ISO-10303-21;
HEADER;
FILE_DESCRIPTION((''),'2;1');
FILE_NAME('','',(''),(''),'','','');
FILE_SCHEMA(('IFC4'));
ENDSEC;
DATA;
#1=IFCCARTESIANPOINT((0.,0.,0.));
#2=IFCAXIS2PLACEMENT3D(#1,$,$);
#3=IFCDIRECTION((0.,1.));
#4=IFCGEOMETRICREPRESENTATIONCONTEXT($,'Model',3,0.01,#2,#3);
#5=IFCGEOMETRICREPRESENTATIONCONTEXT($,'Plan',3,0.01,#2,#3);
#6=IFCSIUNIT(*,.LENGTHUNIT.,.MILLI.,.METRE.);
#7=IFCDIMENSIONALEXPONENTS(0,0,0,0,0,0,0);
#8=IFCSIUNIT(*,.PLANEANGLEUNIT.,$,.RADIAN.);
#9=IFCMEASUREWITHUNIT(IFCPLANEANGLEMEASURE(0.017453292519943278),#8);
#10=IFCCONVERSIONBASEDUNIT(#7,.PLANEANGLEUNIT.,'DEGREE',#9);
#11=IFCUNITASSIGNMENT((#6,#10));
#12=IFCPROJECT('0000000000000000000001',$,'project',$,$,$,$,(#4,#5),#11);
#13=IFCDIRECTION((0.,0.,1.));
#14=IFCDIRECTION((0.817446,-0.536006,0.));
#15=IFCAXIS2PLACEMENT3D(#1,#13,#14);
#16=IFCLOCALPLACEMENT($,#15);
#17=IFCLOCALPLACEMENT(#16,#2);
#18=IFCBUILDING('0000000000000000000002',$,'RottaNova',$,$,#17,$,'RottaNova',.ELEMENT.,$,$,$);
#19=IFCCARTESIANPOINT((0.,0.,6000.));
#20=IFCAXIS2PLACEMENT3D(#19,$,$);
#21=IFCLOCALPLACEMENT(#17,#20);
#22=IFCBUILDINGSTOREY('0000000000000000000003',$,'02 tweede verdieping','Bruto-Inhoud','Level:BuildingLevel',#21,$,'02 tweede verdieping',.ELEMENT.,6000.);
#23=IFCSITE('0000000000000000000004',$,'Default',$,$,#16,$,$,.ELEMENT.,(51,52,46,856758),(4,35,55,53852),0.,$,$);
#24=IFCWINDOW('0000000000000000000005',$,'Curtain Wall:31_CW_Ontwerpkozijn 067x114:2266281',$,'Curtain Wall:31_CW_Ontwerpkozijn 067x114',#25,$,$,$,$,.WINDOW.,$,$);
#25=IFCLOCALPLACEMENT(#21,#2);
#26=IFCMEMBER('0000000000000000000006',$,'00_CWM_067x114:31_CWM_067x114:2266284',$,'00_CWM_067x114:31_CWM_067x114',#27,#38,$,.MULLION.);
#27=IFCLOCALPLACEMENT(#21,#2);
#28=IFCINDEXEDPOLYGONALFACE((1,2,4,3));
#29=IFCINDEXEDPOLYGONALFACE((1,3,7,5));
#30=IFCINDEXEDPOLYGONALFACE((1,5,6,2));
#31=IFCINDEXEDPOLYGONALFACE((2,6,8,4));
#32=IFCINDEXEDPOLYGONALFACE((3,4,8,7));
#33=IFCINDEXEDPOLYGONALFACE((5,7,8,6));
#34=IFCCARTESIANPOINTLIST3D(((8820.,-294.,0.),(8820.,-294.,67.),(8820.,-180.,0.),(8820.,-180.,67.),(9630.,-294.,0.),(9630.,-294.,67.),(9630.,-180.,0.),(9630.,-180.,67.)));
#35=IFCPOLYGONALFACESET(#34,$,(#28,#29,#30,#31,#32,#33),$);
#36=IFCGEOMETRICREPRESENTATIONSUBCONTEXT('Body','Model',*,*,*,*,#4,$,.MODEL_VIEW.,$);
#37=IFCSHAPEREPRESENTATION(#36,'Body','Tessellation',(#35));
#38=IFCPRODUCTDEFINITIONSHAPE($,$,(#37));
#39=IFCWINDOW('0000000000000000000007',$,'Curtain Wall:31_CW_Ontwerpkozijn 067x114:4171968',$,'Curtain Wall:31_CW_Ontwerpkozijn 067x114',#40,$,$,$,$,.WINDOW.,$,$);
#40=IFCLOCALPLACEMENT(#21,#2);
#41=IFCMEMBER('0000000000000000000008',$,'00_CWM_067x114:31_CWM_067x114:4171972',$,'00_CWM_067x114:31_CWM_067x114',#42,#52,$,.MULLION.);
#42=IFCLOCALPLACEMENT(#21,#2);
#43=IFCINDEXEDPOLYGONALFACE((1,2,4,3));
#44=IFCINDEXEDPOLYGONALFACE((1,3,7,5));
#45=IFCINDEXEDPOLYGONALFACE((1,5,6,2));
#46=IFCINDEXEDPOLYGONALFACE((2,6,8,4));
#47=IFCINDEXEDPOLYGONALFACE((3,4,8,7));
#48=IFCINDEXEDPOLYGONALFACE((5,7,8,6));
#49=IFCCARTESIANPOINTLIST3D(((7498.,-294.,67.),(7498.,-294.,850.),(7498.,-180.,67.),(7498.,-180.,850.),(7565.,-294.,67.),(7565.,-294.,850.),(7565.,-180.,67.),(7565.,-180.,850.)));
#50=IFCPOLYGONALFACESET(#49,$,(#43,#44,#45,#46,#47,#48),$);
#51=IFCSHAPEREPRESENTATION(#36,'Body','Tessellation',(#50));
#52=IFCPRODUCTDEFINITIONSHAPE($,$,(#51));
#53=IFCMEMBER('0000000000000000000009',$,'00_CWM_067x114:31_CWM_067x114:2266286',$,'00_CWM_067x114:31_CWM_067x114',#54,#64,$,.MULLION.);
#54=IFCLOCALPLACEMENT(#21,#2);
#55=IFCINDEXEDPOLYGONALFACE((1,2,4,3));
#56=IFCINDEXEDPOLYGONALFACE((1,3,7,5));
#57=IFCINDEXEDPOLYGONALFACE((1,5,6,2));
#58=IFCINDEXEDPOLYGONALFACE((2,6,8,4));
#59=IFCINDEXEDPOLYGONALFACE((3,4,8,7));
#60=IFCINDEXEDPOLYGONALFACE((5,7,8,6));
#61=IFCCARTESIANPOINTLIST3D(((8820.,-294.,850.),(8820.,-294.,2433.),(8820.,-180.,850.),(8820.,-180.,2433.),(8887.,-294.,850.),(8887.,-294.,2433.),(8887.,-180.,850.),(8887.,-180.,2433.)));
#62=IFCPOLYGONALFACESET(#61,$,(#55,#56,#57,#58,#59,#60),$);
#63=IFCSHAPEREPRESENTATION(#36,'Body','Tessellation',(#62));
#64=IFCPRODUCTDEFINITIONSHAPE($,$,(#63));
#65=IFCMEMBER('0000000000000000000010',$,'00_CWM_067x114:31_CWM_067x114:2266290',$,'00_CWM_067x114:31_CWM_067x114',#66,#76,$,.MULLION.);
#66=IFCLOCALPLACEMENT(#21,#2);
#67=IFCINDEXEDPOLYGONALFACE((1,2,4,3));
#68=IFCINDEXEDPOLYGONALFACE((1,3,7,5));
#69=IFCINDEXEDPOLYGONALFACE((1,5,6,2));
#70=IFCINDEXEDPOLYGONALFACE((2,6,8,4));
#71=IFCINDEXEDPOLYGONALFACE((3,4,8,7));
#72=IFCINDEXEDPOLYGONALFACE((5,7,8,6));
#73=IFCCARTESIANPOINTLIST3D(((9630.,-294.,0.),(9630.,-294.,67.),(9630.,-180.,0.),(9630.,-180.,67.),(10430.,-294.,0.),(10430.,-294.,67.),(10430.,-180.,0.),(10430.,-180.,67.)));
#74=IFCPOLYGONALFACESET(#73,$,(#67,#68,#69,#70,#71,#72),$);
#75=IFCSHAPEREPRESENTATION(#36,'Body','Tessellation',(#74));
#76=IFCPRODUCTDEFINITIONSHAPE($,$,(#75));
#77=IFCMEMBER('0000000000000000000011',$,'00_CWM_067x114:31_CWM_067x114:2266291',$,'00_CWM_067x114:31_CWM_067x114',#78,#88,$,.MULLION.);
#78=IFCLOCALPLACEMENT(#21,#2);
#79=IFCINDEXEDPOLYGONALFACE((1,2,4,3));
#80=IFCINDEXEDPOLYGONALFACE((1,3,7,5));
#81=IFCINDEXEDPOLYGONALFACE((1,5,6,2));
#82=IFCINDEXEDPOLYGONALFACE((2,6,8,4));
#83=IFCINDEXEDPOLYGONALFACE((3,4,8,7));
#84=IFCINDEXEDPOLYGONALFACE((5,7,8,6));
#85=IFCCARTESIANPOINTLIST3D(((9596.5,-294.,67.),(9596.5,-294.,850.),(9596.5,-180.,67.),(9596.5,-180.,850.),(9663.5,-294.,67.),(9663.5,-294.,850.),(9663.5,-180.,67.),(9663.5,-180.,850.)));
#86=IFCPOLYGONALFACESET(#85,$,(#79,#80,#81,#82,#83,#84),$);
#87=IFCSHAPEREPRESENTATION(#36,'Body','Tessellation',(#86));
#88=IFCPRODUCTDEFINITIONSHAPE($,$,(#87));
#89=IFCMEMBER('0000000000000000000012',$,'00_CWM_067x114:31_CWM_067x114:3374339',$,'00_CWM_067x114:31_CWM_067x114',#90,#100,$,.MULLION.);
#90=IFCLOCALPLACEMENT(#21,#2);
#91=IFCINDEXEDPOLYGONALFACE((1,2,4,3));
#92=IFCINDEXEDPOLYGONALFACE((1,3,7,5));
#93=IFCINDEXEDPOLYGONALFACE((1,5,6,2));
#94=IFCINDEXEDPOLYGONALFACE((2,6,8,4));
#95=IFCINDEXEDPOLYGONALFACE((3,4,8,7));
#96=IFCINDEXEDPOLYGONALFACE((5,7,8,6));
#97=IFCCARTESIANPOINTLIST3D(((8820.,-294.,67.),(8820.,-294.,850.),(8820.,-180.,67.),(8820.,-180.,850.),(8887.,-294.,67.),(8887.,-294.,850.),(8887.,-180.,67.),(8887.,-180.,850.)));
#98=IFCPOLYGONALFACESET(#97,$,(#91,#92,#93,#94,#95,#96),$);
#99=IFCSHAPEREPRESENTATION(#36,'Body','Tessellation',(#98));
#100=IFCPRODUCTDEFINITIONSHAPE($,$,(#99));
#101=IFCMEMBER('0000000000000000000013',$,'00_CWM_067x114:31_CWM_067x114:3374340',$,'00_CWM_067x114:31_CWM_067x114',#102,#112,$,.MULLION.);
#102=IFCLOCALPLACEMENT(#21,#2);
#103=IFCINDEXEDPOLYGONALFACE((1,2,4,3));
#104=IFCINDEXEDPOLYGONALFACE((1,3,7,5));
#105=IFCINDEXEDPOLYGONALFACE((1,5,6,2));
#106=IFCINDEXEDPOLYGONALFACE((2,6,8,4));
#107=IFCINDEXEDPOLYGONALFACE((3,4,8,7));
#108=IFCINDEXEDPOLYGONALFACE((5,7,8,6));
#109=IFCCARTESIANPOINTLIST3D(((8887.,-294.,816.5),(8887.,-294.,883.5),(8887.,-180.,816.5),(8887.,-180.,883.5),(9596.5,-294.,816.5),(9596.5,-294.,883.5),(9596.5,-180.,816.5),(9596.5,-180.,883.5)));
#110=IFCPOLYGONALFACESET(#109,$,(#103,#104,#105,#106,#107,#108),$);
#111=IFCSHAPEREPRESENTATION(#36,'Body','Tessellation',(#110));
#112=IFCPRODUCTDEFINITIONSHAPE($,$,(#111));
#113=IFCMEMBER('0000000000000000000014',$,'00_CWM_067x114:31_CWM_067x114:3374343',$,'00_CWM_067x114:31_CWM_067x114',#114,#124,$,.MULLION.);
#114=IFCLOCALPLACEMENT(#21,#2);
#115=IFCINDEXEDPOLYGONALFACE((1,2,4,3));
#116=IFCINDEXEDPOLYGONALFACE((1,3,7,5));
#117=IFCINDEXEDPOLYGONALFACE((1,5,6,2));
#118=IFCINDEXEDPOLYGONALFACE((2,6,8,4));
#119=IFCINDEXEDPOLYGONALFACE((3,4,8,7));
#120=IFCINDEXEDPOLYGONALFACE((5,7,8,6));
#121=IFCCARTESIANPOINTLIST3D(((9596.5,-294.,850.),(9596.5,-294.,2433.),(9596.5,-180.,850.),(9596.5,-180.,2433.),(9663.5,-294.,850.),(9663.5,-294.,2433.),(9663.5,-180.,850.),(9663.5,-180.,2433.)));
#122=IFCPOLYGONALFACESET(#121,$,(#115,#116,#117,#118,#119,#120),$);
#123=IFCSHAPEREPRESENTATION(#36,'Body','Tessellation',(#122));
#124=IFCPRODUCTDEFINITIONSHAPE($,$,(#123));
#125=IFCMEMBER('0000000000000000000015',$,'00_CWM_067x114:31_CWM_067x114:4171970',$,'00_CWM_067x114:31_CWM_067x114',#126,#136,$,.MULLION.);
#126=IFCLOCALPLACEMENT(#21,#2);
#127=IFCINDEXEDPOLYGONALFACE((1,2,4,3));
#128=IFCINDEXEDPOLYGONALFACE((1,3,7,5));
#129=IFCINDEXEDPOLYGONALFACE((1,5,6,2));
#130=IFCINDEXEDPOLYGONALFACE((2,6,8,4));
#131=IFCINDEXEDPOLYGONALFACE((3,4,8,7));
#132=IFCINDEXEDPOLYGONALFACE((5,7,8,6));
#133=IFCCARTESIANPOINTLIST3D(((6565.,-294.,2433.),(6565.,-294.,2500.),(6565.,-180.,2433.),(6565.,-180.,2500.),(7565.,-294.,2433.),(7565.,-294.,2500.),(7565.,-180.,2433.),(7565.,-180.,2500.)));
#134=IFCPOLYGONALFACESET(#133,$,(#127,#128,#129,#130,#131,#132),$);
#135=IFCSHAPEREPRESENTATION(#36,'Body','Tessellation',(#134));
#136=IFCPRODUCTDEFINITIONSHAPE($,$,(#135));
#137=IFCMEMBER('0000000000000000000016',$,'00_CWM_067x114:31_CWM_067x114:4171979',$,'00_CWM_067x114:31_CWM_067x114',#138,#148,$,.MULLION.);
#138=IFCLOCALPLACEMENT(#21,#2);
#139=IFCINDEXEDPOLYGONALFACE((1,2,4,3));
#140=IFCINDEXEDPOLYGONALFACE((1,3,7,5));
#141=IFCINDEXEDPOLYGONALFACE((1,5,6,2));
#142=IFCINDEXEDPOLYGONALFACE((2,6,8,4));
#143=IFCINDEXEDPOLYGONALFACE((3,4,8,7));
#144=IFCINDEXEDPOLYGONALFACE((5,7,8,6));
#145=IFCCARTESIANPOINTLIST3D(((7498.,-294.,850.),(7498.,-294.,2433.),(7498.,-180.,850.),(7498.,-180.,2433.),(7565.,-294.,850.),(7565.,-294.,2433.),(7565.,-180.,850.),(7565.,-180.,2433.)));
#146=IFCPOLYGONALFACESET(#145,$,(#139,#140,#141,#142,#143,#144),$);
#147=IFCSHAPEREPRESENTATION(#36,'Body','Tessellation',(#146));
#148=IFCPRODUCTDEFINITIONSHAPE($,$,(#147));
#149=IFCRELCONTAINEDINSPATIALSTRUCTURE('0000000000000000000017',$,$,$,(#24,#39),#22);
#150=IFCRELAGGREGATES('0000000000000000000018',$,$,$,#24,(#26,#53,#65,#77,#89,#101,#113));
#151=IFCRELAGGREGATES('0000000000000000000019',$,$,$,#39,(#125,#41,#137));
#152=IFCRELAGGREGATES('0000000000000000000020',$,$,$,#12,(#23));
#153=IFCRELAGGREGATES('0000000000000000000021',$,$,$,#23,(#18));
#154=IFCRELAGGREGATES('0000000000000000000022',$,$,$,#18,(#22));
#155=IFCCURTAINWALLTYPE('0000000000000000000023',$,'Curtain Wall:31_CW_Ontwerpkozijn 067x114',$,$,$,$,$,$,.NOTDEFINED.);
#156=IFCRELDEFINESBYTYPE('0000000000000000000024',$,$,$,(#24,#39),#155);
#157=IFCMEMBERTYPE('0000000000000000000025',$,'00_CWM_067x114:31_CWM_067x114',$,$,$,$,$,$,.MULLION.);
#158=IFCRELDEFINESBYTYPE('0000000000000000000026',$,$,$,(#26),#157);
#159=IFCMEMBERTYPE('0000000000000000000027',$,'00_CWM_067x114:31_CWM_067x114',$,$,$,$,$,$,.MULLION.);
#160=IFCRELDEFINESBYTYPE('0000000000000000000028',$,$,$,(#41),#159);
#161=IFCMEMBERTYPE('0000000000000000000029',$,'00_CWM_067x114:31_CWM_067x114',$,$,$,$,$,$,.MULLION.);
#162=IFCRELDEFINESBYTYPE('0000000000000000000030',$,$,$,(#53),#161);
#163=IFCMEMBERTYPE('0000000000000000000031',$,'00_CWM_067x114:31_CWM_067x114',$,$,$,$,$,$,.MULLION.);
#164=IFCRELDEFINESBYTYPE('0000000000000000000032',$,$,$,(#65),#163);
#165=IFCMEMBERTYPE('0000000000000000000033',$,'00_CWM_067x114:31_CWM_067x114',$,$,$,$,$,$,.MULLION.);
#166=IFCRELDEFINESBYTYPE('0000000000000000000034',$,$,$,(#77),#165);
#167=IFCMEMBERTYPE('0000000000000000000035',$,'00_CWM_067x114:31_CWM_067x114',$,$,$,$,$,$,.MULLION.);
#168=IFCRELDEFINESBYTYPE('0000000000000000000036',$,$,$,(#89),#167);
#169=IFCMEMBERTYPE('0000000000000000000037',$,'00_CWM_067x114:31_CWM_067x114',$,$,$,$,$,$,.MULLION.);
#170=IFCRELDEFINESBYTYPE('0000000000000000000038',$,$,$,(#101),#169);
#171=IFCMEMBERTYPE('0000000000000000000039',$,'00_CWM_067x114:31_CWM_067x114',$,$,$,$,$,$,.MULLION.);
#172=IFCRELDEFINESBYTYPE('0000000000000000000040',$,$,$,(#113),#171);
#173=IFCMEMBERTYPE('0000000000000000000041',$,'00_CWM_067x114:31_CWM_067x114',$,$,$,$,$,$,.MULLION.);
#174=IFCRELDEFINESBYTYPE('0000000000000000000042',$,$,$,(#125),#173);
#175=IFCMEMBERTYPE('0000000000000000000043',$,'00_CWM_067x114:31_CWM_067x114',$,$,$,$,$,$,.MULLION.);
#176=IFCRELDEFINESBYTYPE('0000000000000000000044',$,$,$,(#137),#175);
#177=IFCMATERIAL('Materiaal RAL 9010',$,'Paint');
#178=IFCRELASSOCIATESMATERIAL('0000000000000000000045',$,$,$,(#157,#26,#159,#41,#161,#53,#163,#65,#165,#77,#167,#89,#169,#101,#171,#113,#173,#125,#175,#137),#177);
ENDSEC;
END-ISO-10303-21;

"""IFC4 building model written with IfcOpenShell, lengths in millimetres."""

from ifc_helpers import new_model, entity, si_unit, converted_unit, direction, frame, origin, place, context, subcontext, project, spatial, indexed_curve, outline, extrude, source, transform, mapped, material, type_object, type_shapes, element, aggregate, save


model = new_model("IFC4")

# Units and contexts
model_context = context("Model", 3, precision=0.01, world=origin(), true_north=direction((0.0, 1.0)))
plan_context = context("Plan", 3, precision=0.01, world=origin(), true_north=direction((0.0, 1.0)))
body_context = subcontext(model_context, "Body", "Model", "MODEL_VIEW")
ifc_project = project(units=[si_unit("LENGTHUNIT", "METRE", prefix="MILLI"), converted_unit("PLANEANGLEUNIT", "DEGREE", entity("IfcPlaneAngleMeasure", 0.017453292519943278), si_unit("PLANEANGLEUNIT", "RADIAN"), dimensions=[0, 0, 0, 0, 0, 0, 0])], contexts=[model_context, plan_context])

# Site, building, storey
site_placement = place(None, frame((0.0, 0.0, 0.0), z_axis=(0.0, 0.0, 1.0), x_axis=(0.817446, -0.536006, 0.0)))
site = spatial("IfcSite", under=ifc_project, at=site_placement, Name="Default", CompositionType="ELEMENT", RefLatitude=(51, 52, 46, 856758), RefLongitude=(4, 35, 55, 53852), RefElevation=0.0)
building_placement = place(site_placement, origin())
building = spatial("IfcBuilding", under=site, at=building_placement, Name="RottaNova", LongName="RottaNova", CompositionType="ELEMENT")
storey_placement = place(building_placement, frame((0.0, 0.0, 6000.0)))
storey = spatial("IfcBuildingStorey", under=building, at=storey_placement, Name="02 tweede verdieping", Description="Bruto-Inhoud", ObjectType="Level:BuildingLevel", LongName="02 tweede verdieping", CompositionType="ELEMENT", Elevation=6000.0)

# Windows, members
curtain_wall_type = type_object("IfcCurtainWallType", Name="Curtain Wall:31_CW_Ontwerpkozijn 067x114", PredefinedType="NOTDEFINED")
window_1_placement = place(storey_placement, frame((0.0, 0.0, -6000.0)))
window_1 = element("IfcWindow", 1, at=window_1_placement, inside=storey, type_object=curtain_wall_type, Name="Curtain Wall:31_CW_Ontwerpkozijn 067x114:2266281", ObjectType="Curtain Wall:31_CW_Ontwerpkozijn 067x114", PredefinedType="WINDOW")
ifc_material_1 = material(Name="Materiaal RAL 9010", Category="Paint")
member_type_1 = type_object("IfcMemberType", Name="00_CWM_067x114:31_CWM_067x114", PredefinedType="MULLION", material=ifc_material_1)
shared_shape_1 = source(origin(), body_context, "Body", "SweptSolid", [
    extrude(outline(indexed_curve([(-33.5, -57.0), (33.5, -57.0), (33.5, 57.0), (-33.5, 57.0), (-33.5, -57.0)], self_intersect=False)), frame((-33.5, 57.0, -810.0), z_axis=(0.0, 0.0, 1.0), x_axis=(-1.0, 0.0, 0.0)), (0.0, 0.0, 1.0), 810.0),
])
type_shapes(member_type_1, [shared_shape_1])
member_1_placement = place(window_1_placement, frame((8820.0, -180.0, 6000.0), z_axis=(-1.0, 0.0, 0.0), x_axis=(0.0, 0.0, -1.0)))
member_1 = element("IfcMember", 2, at=member_1_placement, type_object=member_type_1, material=ifc_material_1, Name="00_CWM_067x114:31_CWM_067x114:2266284", ObjectType="00_CWM_067x114:31_CWM_067x114", PredefinedType="MULLION", context=body_context, shape_type="MappedRepresentation", body=[
    mapped(shared_shape_1, transform((0.0, 0.0, 0.0), scale=1.0)),
])
window_2_placement = place(storey_placement, frame((0.0, 0.0, -6000.0)))
window_2 = element("IfcWindow", 3, at=window_2_placement, inside=storey, type_object=curtain_wall_type, Name="Curtain Wall:31_CW_Ontwerpkozijn 067x114:4171968", ObjectType="Curtain Wall:31_CW_Ontwerpkozijn 067x114", PredefinedType="WINDOW")
member_type_2 = type_object("IfcMemberType", Name="00_CWM_067x114:31_CWM_067x114", PredefinedType="MULLION", material=ifc_material_1)
shared_shape_2 = source(origin(), body_context, "Body", "SweptSolid", [
    extrude(outline(indexed_curve([(-33.5, -57.0), (33.5, -57.0), (33.5, 57.0), (-33.5, 57.0), (-33.5, -57.0)], self_intersect=False)), frame((-33.5, 57.0, -783.0), z_axis=(0.0, 0.0, 1.0), x_axis=(-1.0, 0.0, 0.0)), (0.0, 0.0, 1.0), 783.0),
])
type_shapes(member_type_2, [shared_shape_2])
member_2_placement = place(window_2_placement, frame((7565.0, -180.0, 6067.0), z_axis=(0.0, 0.0, -1.0), x_axis=(1.0, 0.0, 0.0)))
member_2 = element("IfcMember", 4, at=member_2_placement, type_object=member_type_2, material=ifc_material_1, Name="00_CWM_067x114:31_CWM_067x114:4171972", ObjectType="00_CWM_067x114:31_CWM_067x114", PredefinedType="MULLION", context=body_context, shape_type="MappedRepresentation", body=[
    mapped(shared_shape_2, transform((0.0, 0.0, 0.0), scale=1.0)),
])

# Members
member_type_3 = type_object("IfcMemberType", Name="00_CWM_067x114:31_CWM_067x114", PredefinedType="MULLION", material=ifc_material_1)
shared_shape_3 = source(origin(), body_context, "Body", "SweptSolid", [
    extrude(outline(indexed_curve([(-33.5, -57.0), (33.5, -57.0), (33.5, 57.0), (-33.5, 57.0), (-33.5, -57.0)], self_intersect=False)), frame((-33.5, 57.0, -1583.0), z_axis=(0.0, 0.0, 1.0), x_axis=(-1.0, 0.0, 0.0)), (0.0, 0.0, 1.0), 1583.0),
])
type_shapes(member_type_3, [shared_shape_3])
member_3_placement = place(window_1_placement, frame((8820.0, -180.0, 8433.0), z_axis=(0.0, 0.0, 1.0), x_axis=(-1.0, 0.0, 0.0)))
member_3 = element("IfcMember", 5, at=member_3_placement, type_object=member_type_3, material=ifc_material_1, Name="00_CWM_067x114:31_CWM_067x114:2266286", ObjectType="00_CWM_067x114:31_CWM_067x114", PredefinedType="MULLION", context=body_context, shape_type="MappedRepresentation", body=[
    mapped(shared_shape_3, transform((0.0, 0.0, 0.0), scale=1.0)),
])
member_type_4 = type_object("IfcMemberType", Name="00_CWM_067x114:31_CWM_067x114", PredefinedType="MULLION", material=ifc_material_1)
shared_shape_4 = source(origin(), body_context, "Body", "SweptSolid", [
    extrude(outline(indexed_curve([(-33.5, -57.0), (33.5, -57.0), (33.5, 57.0), (-33.5, 57.0), (-33.5, -57.0)], self_intersect=False)), frame((-33.5, 57.0, -800.0), z_axis=(0.0, 0.0, 1.0), x_axis=(-1.0, 0.0, 0.0)), (0.0, 0.0, 1.0), 800.0),
])
type_shapes(member_type_4, [shared_shape_4])
member_4_placement = place(window_1_placement, frame((9630.0, -180.0, 6000.0), z_axis=(-1.0, 0.0, 0.0), x_axis=(0.0, 0.0, -1.0)))
member_4 = element("IfcMember", 6, at=member_4_placement, type_object=member_type_4, material=ifc_material_1, Name="00_CWM_067x114:31_CWM_067x114:2266290", ObjectType="00_CWM_067x114:31_CWM_067x114", PredefinedType="MULLION", context=body_context, shape_type="MappedRepresentation", body=[
    mapped(shared_shape_4, transform((0.0, 0.0, 0.0), scale=1.0)),
])
member_type_5 = type_object("IfcMemberType", Name="00_CWM_067x114:31_CWM_067x114", PredefinedType="MULLION", material=ifc_material_1)
shared_shape_5 = source(origin(), body_context, "Body", "SweptSolid", [
    extrude(outline(indexed_curve([(-33.5, -57.0), (33.5, -57.0), (33.5, 57.0), (-33.5, 57.0), (-33.5, -57.0)], self_intersect=False)), frame((0.0, 57.0, -783.0), z_axis=(0.0, 0.0, 1.0), x_axis=(-1.0, 0.0, 0.0)), (0.0, 0.0, 1.0), 783.0),
])
type_shapes(member_type_5, [shared_shape_5])
member_5_placement = place(window_1_placement, frame((9630.0, -180.0, 6067.0), z_axis=(0.0, 0.0, -1.0), x_axis=(1.0, 0.0, 0.0)))
member_5 = element("IfcMember", 7, at=member_5_placement, type_object=member_type_5, material=ifc_material_1, Name="00_CWM_067x114:31_CWM_067x114:2266291", ObjectType="00_CWM_067x114:31_CWM_067x114", PredefinedType="MULLION", context=body_context, shape_type="MappedRepresentation", body=[
    mapped(shared_shape_5, transform((0.0, 0.0, 0.0), scale=1.0)),
])
member_type_6 = type_object("IfcMemberType", Name="00_CWM_067x114:31_CWM_067x114", PredefinedType="MULLION", material=ifc_material_1)
shared_shape_6 = source(origin(), body_context, "Body", "SweptSolid", [
    extrude(outline(indexed_curve([(-33.5, -57.0), (33.5, -57.0), (33.5, 57.0), (-33.5, 57.0), (-33.5, -57.0)], self_intersect=False)), frame((-33.5, 57.0, -783.0), z_axis=(0.0, 0.0, 1.0), x_axis=(-1.0, 0.0, 0.0)), (0.0, 0.0, 1.0), 783.0),
])
type_shapes(member_type_6, [shared_shape_6])
member_6_placement = place(window_1_placement, frame((8820.0, -180.0, 6850.0), z_axis=(0.0, 0.0, 1.0), x_axis=(-1.0, 0.0, 0.0)))
member_6 = element("IfcMember", 8, at=member_6_placement, type_object=member_type_6, material=ifc_material_1, Name="00_CWM_067x114:31_CWM_067x114:3374339", ObjectType="00_CWM_067x114:31_CWM_067x114", PredefinedType="MULLION", context=body_context, shape_type="MappedRepresentation", body=[
    mapped(shared_shape_6, transform((0.0, 0.0, 0.0), scale=1.0)),
])
member_type_7 = type_object("IfcMemberType", Name="00_CWM_067x114:31_CWM_067x114", PredefinedType="MULLION", material=ifc_material_1)
shared_shape_7 = source(origin(), body_context, "Body", "SweptSolid", [
    extrude(outline(indexed_curve([(-33.5, -57.0), (33.5, -57.0), (33.5, 57.0), (-33.5, 57.0), (-33.5, -57.0)], self_intersect=False)), frame((0.0, 57.0, -709.5), z_axis=(0.0, 0.0, 1.0), x_axis=(-1.0, 0.0, 0.0)), (0.0, 0.0, 1.0), 709.5),
])
type_shapes(member_type_7, [shared_shape_7])
member_7_placement = place(window_1_placement, frame((9596.5, -180.0, 6850.0), z_axis=(1.0, 0.0, 0.0), x_axis=(0.0, 0.0, 1.0)))
member_7 = element("IfcMember", 9, at=member_7_placement, type_object=member_type_7, material=ifc_material_1, Name="00_CWM_067x114:31_CWM_067x114:3374340", ObjectType="00_CWM_067x114:31_CWM_067x114", PredefinedType="MULLION", context=body_context, shape_type="MappedRepresentation", body=[
    mapped(shared_shape_7, transform((0.0, 0.0, 0.0), scale=1.0)),
])
member_type_8 = type_object("IfcMemberType", Name="00_CWM_067x114:31_CWM_067x114", PredefinedType="MULLION", material=ifc_material_1)
shared_shape_8 = source(origin(), body_context, "Body", "SweptSolid", [
    extrude(outline(indexed_curve([(-33.5, -57.0), (33.5, -57.0), (33.5, 57.0), (-33.5, 57.0), (-33.5, -57.0)], self_intersect=False)), frame((0.0, 57.0, -1583.0), z_axis=(0.0, 0.0, 1.0), x_axis=(-1.0, 0.0, 0.0)), (0.0, 0.0, 1.0), 1583.0),
])
type_shapes(member_type_8, [shared_shape_8])
member_8_placement = place(window_1_placement, frame((9630.0, -180.0, 6850.0), z_axis=(0.0, 0.0, -1.0), x_axis=(1.0, 0.0, 0.0)))
member_8 = element("IfcMember", 10, at=member_8_placement, type_object=member_type_8, material=ifc_material_1, Name="00_CWM_067x114:31_CWM_067x114:3374343", ObjectType="00_CWM_067x114:31_CWM_067x114", PredefinedType="MULLION", context=body_context, shape_type="MappedRepresentation", body=[
    mapped(shared_shape_8, transform((0.0, 0.0, 0.0), scale=1.0)),
])
member_type_9 = type_object("IfcMemberType", Name="00_CWM_067x114:31_CWM_067x114", PredefinedType="MULLION", material=ifc_material_1)
shared_shape_9 = source(origin(), body_context, "Body", "SweptSolid", [
    extrude(outline(indexed_curve([(-33.5, -57.0), (33.5, -57.0), (33.5, 57.0), (-33.5, 57.0), (-33.5, -57.0)], self_intersect=False)), frame((-33.5, 57.0, -1000.0), z_axis=(0.0, 0.0, 1.0), x_axis=(-1.0, 0.0, 0.0)), (0.0, 0.0, 1.0), 1000.0),
])
type_shapes(member_type_9, [shared_shape_9])
member_9_placement = place(window_2_placement, frame((7565.0, -180.0, 8500.0), z_axis=(1.0, 0.0, 0.0), x_axis=(0.0, 0.0, 1.0)))
member_9 = element("IfcMember", 11, at=member_9_placement, type_object=member_type_9, material=ifc_material_1, Name="00_CWM_067x114:31_CWM_067x114:4171970", ObjectType="00_CWM_067x114:31_CWM_067x114", PredefinedType="MULLION", context=body_context, shape_type="MappedRepresentation", body=[
    mapped(shared_shape_9, transform((0.0, 0.0, 0.0), scale=1.0)),
])
member_type_10 = type_object("IfcMemberType", Name="00_CWM_067x114:31_CWM_067x114", PredefinedType="MULLION", material=ifc_material_1)
shared_shape_10 = source(origin(), body_context, "Body", "SweptSolid", [
    extrude(outline(indexed_curve([(-33.5, -57.0), (33.5, -57.0), (33.5, 57.0), (-33.5, 57.0), (-33.5, -57.0)], self_intersect=False)), frame((-33.5, 57.0, -1583.0), z_axis=(0.0, 0.0, 1.0), x_axis=(-1.0, 0.0, 0.0)), (0.0, 0.0, 1.0), 1583.0),
])
type_shapes(member_type_10, [shared_shape_10])
member_10_placement = place(window_2_placement, frame((7565.0, -180.0, 6850.0), z_axis=(0.0, 0.0, -1.0), x_axis=(1.0, 0.0, 0.0)))
member_10 = element("IfcMember", 12, at=member_10_placement, type_object=member_type_10, material=ifc_material_1, Name="00_CWM_067x114:31_CWM_067x114:4171979", ObjectType="00_CWM_067x114:31_CWM_067x114", PredefinedType="MULLION", context=body_context, shape_type="MappedRepresentation", body=[
    mapped(shared_shape_10, transform((0.0, 0.0, 0.0), scale=1.0)),
])

aggregate(window_1, [member_1, member_3, member_4, member_5, member_6, member_7, member_8])
aggregate(window_2, [member_9, member_2, member_10])

save(model, "model.ifc")
